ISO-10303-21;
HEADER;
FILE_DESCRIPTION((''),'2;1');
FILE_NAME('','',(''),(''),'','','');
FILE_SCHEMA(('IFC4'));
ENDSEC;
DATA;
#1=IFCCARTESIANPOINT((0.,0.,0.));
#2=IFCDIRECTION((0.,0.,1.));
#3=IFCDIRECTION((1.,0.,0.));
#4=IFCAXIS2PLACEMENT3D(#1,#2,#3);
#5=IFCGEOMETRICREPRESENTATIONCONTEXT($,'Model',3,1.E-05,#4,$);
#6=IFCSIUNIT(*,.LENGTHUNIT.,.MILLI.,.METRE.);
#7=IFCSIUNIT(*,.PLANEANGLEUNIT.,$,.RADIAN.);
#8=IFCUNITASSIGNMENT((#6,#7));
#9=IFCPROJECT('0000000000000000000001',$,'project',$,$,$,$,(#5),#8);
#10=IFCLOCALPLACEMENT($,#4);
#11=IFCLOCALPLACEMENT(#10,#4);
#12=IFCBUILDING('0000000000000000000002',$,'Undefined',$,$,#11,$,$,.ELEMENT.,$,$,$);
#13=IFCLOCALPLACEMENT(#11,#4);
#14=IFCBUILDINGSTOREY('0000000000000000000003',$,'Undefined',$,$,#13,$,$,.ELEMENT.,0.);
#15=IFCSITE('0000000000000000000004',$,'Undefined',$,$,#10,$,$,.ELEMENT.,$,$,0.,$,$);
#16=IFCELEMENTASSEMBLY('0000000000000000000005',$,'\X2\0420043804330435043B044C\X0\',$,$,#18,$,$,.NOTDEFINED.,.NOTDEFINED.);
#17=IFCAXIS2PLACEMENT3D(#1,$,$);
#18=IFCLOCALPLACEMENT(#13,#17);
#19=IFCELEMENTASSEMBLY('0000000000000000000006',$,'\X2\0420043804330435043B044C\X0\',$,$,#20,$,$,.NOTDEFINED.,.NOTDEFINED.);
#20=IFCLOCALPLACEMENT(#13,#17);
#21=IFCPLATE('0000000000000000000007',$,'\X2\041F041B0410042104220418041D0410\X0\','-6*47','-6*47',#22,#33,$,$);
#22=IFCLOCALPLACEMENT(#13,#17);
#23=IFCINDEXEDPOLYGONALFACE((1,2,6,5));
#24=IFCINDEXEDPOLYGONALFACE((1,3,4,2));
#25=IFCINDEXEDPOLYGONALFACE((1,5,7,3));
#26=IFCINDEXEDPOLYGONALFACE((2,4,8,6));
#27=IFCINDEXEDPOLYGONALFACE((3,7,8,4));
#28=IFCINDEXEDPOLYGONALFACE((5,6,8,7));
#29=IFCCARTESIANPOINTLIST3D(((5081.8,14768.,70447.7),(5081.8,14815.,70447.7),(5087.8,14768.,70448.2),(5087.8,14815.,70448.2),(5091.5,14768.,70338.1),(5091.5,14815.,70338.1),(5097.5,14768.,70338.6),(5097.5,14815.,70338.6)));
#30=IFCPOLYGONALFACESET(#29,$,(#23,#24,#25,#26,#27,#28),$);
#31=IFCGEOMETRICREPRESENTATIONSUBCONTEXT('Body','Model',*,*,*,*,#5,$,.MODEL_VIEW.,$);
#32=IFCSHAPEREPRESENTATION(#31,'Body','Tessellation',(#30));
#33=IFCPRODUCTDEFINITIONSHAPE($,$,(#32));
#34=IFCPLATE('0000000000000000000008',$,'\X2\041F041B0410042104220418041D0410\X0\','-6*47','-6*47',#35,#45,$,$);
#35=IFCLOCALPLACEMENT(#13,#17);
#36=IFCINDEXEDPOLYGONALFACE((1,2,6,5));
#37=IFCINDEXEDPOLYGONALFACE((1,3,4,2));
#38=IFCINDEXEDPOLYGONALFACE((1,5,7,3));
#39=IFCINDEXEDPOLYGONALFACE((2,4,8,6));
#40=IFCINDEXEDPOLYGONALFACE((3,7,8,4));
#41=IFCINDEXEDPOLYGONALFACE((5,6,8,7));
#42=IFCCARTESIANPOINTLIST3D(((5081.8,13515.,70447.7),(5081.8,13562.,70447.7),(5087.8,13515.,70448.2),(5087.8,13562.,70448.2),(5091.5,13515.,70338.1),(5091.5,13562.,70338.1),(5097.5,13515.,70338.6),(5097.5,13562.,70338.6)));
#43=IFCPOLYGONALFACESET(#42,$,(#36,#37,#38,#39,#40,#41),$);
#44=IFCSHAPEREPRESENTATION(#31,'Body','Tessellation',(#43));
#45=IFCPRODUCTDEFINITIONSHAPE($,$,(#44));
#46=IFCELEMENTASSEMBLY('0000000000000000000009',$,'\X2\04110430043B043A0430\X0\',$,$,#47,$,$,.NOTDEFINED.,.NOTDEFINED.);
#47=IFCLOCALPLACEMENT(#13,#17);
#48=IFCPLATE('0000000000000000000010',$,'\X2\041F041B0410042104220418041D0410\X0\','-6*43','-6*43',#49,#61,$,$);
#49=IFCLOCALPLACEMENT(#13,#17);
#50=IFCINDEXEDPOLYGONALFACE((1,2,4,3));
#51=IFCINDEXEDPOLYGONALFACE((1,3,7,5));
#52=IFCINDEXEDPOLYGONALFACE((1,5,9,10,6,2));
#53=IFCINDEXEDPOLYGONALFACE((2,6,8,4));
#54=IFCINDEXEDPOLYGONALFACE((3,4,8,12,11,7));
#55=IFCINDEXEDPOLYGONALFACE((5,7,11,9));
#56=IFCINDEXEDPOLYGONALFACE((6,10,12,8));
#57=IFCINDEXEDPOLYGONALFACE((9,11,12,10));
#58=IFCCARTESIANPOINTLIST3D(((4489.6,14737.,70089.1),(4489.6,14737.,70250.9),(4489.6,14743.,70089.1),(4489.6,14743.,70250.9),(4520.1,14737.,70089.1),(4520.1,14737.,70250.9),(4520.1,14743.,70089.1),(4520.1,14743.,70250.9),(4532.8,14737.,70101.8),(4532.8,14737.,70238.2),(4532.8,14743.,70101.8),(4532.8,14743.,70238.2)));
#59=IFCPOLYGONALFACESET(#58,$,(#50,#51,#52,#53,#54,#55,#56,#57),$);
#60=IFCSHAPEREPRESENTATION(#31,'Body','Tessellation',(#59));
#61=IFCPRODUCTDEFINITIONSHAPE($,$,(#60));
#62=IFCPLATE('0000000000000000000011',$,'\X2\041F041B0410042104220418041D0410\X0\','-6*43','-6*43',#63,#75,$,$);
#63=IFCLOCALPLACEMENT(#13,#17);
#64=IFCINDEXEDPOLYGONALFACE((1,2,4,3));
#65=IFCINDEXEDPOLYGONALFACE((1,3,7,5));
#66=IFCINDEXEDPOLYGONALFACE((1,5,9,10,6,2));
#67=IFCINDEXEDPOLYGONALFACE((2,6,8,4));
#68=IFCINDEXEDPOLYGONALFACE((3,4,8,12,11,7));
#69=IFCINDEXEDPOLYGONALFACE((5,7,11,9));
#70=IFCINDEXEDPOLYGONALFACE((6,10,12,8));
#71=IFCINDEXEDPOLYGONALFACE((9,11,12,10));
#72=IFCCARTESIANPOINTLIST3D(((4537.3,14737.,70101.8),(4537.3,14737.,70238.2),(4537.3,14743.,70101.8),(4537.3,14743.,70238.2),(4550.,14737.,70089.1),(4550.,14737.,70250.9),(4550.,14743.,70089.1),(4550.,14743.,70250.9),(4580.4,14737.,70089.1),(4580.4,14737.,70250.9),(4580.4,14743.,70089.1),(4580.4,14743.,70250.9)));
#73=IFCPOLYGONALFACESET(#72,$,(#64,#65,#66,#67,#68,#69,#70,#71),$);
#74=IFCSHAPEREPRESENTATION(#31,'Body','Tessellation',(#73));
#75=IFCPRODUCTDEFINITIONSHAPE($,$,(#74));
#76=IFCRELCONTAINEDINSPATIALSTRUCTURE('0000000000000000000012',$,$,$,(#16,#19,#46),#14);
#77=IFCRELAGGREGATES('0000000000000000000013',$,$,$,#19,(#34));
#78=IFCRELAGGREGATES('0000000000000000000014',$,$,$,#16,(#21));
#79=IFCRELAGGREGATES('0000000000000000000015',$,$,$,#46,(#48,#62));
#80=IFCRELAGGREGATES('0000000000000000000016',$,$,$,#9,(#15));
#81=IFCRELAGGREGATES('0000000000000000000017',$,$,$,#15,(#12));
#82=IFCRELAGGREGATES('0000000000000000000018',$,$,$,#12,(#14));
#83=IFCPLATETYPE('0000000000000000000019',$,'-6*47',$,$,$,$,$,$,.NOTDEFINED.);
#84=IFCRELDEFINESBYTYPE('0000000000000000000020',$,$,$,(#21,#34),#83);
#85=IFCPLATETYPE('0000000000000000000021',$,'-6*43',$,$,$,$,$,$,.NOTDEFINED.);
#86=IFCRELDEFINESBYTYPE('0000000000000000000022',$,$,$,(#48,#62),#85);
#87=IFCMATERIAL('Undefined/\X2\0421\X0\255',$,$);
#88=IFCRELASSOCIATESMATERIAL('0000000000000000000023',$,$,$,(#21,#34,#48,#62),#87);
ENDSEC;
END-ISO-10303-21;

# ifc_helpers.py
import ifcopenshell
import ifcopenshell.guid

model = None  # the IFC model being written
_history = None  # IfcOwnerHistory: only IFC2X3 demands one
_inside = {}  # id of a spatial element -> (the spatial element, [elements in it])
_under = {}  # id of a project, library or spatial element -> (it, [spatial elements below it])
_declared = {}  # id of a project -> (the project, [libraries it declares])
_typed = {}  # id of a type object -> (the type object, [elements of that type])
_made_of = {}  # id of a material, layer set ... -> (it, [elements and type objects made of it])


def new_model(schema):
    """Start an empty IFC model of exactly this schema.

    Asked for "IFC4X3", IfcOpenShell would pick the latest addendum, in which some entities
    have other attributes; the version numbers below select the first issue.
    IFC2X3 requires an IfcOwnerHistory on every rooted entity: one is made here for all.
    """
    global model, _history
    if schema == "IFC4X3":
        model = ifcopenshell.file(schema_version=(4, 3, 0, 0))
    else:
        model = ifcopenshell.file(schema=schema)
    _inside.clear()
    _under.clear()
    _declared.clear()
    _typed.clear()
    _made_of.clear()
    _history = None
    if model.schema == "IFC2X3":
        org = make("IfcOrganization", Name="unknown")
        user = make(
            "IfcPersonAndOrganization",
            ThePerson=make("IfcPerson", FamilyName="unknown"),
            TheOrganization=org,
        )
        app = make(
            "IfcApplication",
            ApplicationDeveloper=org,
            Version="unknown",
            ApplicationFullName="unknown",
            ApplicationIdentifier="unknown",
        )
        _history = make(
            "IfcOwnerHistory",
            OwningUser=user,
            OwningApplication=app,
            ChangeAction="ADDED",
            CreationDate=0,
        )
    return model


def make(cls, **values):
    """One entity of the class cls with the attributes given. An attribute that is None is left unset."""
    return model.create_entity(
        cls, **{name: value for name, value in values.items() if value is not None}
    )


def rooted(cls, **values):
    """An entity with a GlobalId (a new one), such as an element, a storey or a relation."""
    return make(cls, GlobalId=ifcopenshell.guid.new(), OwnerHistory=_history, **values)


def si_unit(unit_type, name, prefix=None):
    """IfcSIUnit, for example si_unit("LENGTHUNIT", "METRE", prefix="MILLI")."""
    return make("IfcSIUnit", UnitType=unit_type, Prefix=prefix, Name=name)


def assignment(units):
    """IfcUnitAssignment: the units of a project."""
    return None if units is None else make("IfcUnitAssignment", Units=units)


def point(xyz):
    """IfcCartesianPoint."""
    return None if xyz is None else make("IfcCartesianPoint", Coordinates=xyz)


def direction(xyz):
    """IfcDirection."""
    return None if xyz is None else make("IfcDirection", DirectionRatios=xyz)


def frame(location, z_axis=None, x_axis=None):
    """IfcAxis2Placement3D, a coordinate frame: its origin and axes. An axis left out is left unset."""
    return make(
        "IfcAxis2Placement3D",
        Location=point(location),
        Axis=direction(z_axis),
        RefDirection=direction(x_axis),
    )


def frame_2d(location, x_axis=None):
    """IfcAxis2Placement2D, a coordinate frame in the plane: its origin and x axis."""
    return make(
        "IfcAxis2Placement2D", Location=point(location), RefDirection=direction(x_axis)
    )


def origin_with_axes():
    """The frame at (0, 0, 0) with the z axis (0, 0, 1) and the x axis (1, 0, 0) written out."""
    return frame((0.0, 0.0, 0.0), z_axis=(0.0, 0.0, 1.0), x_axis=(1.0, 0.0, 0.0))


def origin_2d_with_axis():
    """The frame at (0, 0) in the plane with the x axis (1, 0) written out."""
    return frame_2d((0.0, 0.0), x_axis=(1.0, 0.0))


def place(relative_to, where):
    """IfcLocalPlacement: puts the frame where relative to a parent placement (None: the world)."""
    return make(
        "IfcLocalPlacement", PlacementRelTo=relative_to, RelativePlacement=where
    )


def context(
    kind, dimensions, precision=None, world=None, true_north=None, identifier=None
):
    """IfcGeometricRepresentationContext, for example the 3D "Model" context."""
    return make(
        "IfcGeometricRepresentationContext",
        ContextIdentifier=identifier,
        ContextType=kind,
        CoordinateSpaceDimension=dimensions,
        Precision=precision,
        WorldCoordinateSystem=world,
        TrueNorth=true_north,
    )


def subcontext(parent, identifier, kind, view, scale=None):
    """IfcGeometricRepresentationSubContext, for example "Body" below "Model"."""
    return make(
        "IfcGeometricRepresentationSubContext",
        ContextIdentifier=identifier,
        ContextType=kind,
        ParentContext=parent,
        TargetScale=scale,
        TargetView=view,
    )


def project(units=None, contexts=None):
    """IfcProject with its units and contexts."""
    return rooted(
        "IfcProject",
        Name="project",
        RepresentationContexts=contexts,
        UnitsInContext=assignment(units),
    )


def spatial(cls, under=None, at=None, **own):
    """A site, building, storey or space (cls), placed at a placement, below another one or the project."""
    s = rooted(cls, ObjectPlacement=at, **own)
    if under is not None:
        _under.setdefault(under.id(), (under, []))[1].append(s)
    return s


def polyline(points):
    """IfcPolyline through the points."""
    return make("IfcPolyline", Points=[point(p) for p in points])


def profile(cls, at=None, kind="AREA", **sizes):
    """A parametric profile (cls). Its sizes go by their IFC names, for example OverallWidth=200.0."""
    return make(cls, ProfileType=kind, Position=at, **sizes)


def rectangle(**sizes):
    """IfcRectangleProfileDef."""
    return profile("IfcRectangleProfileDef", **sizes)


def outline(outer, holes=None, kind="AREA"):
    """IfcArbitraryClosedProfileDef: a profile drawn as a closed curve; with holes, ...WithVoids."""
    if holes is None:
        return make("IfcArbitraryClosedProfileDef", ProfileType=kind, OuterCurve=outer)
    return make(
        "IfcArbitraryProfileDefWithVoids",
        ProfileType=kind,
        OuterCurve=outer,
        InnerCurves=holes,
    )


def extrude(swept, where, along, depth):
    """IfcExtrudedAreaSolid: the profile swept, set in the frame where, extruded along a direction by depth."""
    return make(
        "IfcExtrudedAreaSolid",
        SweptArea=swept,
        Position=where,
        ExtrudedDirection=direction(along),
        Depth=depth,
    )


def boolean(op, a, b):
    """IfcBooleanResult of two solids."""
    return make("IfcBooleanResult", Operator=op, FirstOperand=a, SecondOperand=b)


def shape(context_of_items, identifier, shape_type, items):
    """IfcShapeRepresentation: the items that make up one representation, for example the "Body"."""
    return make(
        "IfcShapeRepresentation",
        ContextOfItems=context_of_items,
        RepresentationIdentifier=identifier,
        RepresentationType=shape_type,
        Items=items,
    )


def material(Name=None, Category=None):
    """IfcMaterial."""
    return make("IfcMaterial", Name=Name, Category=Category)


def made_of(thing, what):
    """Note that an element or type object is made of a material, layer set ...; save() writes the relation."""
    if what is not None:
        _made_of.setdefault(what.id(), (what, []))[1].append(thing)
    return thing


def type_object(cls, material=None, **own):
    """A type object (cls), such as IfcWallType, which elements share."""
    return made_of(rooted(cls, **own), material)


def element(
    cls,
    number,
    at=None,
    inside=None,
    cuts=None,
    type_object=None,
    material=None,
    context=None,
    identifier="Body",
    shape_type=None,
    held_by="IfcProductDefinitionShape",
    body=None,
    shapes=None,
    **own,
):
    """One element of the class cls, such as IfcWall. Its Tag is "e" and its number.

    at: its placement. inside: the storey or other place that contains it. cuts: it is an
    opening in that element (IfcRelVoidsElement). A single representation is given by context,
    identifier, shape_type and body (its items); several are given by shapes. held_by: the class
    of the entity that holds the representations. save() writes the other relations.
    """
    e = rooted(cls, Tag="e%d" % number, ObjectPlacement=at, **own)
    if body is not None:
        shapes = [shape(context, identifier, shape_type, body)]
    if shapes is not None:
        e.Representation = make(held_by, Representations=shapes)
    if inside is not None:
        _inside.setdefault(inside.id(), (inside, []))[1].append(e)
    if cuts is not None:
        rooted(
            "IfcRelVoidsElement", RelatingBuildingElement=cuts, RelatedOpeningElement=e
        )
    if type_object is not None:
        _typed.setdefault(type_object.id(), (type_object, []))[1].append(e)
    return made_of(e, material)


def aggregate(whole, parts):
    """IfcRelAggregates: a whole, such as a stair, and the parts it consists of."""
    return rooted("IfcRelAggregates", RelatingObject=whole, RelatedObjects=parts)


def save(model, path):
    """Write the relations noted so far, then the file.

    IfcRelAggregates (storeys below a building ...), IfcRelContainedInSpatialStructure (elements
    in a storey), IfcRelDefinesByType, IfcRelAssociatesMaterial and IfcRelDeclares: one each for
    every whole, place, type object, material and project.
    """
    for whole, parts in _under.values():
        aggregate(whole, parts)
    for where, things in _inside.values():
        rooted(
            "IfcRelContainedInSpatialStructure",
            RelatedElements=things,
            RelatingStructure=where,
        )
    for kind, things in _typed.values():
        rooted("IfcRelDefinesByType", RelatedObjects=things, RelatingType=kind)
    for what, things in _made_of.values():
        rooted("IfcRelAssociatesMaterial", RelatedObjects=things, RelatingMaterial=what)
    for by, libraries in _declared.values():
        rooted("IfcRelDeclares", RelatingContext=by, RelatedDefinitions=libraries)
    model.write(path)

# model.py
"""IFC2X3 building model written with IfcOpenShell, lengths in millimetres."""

from ifc_helpers import new_model, si_unit, frame, origin_with_axes, origin_2d_with_axis, place, context, subcontext, project, spatial, polyline, rectangle, outline, extrude, boolean, material, type_object, element, aggregate, save


model = new_model("IFC2X3")

# Units and contexts
model_context = context("Model", 3, precision=1e-05, world=origin_with_axes())
body_context = subcontext(model_context, "Body", "Model", "MODEL_VIEW")
ifc_project = project(units=[si_unit("LENGTHUNIT", "METRE", prefix="MILLI"), si_unit("PLANEANGLEUNIT", "RADIAN")], contexts=[model_context])

# Site, building, storey
site_placement = place(None, origin_with_axes())
site = spatial("IfcSite", under=ifc_project, at=site_placement, Name="Undefined", CompositionType="ELEMENT", RefElevation=0.0)
building_placement = place(site_placement, origin_with_axes())
building = spatial("IfcBuilding", under=site, at=building_placement, Name="Undefined", CompositionType="ELEMENT")
storey_placement = place(building_placement, origin_with_axes())
storey = spatial("IfcBuildingStorey", under=building, at=storey_placement, Name="Undefined", CompositionType="ELEMENT", Elevation=0.0)

# Shared definitions
ifc_material_1 = material(Name="Undefined/С255")

# Element assemblies
assembly_1_placement = place(storey_placement, origin_with_axes())
assembly_1 = element("IfcElementAssembly", 1, at=assembly_1_placement, inside=storey, Name="Ригель", AssemblyPlace="NOTDEFINED", PredefinedType="NOTDEFINED")
assembly_2_placement = place(storey_placement, origin_with_axes())
assembly_2 = element("IfcElementAssembly", 2, at=assembly_2_placement, inside=storey, Name="Ригель", AssemblyPlace="NOTDEFINED", PredefinedType="NOTDEFINED")

# Plates
plate_type_1 = type_object("IfcPlateType", Name="-6*47", PredefinedType="NOTDEFINED")
plate_1_placement = place(assembly_1_placement, frame((5084.8, 14705.0, 70447.9), z_axis=(0.996107, 0.0, 0.088152), x_axis=(0.088152, 0.0, -0.996107)))
plate_1 = element("IfcPlate", 3, at=plate_1_placement, type_object=plate_type_1, material=ifc_material_1, Name="ПЛАСТИНА", Description="-6*47", ObjectType="-6*47", context=body_context, shape_type="CSG", body=[
    boolean("DIFFERENCE", extrude(outline(polyline([(0.0, 0.0), (110.0, 0.0), (110.0, 110.0), (0.0, 110.0), (0.0, 0.0)])), frame((0.0, 0.0, -3.0), z_axis=(0.0, 0.0, 1.0), x_axis=(1.0, 0.0, 0.0)), (0.0, 0.0, 1.0), 6.0), extrude(rectangle(XDim=26.0, YDim=130.0, at=origin_2d_with_axis()), frame((55.0, -3.0, 0.0), z_axis=(0.0, 1.0, 0.0), x_axis=(0.0, 0.0, -1.0)), (0.0, 0.0, 1.0), 66.0)),
])
plate_2_placement = place(assembly_2_placement, frame((5084.8, 13515.0, 70447.9), z_axis=(0.996107, 0.0, 0.088152), x_axis=(0.088152, 0.0, -0.996107)))
plate_2 = element("IfcPlate", 4, at=plate_2_placement, type_object=plate_type_1, material=ifc_material_1, Name="ПЛАСТИНА", Description="-6*47", ObjectType="-6*47", context=body_context, shape_type="CSG", body=[
    boolean("DIFFERENCE", extrude(outline(polyline([(0.0, 0.0), (110.0, 0.0), (110.0, 110.0), (0.0, 110.0), (0.0, 0.0)])), frame((0.0, 0.0, -3.0), z_axis=(0.0, 0.0, 1.0), x_axis=(1.0, 0.0, 0.0)), (0.0, 0.0, 1.0), 6.0), extrude(rectangle(XDim=26.0, YDim=130.0, at=origin_2d_with_axis()), frame((55.0, 47.0, 0.0), z_axis=(0.0, 1.0, 0.0), x_axis=(0.0, 0.0, -1.0)), (0.0, 0.0, 1.0), 66.0)),
])
aggregate(assembly_2, [plate_2])

# Element assembly, plates
assembly_3_placement = place(storey_placement, origin_with_axes())
assembly_3 = element("IfcElementAssembly", 5, at=assembly_3_placement, inside=storey, Name="Балка", AssemblyPlace="NOTDEFINED", PredefinedType="NOTDEFINED")
plate_type_2 = type_object("IfcPlateType", Name="-6*43", PredefinedType="NOTDEFINED")
plate_3_placement = place(assembly_3_placement, frame((4532.8, 14740.0, 70250.9), z_axis=(0.0, -1.0, 0.0), x_axis=(-1.0, 0.0, 0.0)))
plate_3 = element("IfcPlate", 6, at=plate_3_placement, type_object=plate_type_2, material=ifc_material_1, Name="ПЛАСТИНА", Description="-6*43", ObjectType="-6*43", context=body_context, shape_type="SweptSolid", body=[
    extrude(outline(polyline([(0.0, 12.7), (12.7, 0.0), (43.2, 0.0), (43.2, 161.8), (12.7, 161.8), (0.0, 149.1), (0.0, 12.7)])), frame((0.0, 0.0, -3.0), z_axis=(0.0, 0.0, 1.0), x_axis=(1.0, 0.0, 0.0)), (0.0, 0.0, 1.0), 6.0),
])
plate_4_placement = place(assembly_3_placement, frame((4580.4, 14740.0, 70250.9), z_axis=(0.0, -1.0, 0.0), x_axis=(-1.0, 0.0, 0.0)))
plate_4 = element("IfcPlate", 7, at=plate_4_placement, type_object=plate_type_2, material=ifc_material_1, Name="ПЛАСТИНА", Description="-6*43", ObjectType="-6*43", context=body_context, shape_type="SweptSolid", body=[
    extrude(outline(polyline([(0.0, 0.0), (30.5, 0.0), (43.2, 12.7), (43.2, 149.1), (30.5, 161.8), (0.0, 161.8), (0.0, 0.0)])), frame((0.0, 0.0, -3.0), z_axis=(0.0, 0.0, 1.0), x_axis=(1.0, 0.0, 0.0)), (0.0, 0.0, 1.0), 6.0),
])

aggregate(assembly_1, [plate_1])
aggregate(assembly_3, [plate_3, plate_4])

save(model, "model.ifc")
